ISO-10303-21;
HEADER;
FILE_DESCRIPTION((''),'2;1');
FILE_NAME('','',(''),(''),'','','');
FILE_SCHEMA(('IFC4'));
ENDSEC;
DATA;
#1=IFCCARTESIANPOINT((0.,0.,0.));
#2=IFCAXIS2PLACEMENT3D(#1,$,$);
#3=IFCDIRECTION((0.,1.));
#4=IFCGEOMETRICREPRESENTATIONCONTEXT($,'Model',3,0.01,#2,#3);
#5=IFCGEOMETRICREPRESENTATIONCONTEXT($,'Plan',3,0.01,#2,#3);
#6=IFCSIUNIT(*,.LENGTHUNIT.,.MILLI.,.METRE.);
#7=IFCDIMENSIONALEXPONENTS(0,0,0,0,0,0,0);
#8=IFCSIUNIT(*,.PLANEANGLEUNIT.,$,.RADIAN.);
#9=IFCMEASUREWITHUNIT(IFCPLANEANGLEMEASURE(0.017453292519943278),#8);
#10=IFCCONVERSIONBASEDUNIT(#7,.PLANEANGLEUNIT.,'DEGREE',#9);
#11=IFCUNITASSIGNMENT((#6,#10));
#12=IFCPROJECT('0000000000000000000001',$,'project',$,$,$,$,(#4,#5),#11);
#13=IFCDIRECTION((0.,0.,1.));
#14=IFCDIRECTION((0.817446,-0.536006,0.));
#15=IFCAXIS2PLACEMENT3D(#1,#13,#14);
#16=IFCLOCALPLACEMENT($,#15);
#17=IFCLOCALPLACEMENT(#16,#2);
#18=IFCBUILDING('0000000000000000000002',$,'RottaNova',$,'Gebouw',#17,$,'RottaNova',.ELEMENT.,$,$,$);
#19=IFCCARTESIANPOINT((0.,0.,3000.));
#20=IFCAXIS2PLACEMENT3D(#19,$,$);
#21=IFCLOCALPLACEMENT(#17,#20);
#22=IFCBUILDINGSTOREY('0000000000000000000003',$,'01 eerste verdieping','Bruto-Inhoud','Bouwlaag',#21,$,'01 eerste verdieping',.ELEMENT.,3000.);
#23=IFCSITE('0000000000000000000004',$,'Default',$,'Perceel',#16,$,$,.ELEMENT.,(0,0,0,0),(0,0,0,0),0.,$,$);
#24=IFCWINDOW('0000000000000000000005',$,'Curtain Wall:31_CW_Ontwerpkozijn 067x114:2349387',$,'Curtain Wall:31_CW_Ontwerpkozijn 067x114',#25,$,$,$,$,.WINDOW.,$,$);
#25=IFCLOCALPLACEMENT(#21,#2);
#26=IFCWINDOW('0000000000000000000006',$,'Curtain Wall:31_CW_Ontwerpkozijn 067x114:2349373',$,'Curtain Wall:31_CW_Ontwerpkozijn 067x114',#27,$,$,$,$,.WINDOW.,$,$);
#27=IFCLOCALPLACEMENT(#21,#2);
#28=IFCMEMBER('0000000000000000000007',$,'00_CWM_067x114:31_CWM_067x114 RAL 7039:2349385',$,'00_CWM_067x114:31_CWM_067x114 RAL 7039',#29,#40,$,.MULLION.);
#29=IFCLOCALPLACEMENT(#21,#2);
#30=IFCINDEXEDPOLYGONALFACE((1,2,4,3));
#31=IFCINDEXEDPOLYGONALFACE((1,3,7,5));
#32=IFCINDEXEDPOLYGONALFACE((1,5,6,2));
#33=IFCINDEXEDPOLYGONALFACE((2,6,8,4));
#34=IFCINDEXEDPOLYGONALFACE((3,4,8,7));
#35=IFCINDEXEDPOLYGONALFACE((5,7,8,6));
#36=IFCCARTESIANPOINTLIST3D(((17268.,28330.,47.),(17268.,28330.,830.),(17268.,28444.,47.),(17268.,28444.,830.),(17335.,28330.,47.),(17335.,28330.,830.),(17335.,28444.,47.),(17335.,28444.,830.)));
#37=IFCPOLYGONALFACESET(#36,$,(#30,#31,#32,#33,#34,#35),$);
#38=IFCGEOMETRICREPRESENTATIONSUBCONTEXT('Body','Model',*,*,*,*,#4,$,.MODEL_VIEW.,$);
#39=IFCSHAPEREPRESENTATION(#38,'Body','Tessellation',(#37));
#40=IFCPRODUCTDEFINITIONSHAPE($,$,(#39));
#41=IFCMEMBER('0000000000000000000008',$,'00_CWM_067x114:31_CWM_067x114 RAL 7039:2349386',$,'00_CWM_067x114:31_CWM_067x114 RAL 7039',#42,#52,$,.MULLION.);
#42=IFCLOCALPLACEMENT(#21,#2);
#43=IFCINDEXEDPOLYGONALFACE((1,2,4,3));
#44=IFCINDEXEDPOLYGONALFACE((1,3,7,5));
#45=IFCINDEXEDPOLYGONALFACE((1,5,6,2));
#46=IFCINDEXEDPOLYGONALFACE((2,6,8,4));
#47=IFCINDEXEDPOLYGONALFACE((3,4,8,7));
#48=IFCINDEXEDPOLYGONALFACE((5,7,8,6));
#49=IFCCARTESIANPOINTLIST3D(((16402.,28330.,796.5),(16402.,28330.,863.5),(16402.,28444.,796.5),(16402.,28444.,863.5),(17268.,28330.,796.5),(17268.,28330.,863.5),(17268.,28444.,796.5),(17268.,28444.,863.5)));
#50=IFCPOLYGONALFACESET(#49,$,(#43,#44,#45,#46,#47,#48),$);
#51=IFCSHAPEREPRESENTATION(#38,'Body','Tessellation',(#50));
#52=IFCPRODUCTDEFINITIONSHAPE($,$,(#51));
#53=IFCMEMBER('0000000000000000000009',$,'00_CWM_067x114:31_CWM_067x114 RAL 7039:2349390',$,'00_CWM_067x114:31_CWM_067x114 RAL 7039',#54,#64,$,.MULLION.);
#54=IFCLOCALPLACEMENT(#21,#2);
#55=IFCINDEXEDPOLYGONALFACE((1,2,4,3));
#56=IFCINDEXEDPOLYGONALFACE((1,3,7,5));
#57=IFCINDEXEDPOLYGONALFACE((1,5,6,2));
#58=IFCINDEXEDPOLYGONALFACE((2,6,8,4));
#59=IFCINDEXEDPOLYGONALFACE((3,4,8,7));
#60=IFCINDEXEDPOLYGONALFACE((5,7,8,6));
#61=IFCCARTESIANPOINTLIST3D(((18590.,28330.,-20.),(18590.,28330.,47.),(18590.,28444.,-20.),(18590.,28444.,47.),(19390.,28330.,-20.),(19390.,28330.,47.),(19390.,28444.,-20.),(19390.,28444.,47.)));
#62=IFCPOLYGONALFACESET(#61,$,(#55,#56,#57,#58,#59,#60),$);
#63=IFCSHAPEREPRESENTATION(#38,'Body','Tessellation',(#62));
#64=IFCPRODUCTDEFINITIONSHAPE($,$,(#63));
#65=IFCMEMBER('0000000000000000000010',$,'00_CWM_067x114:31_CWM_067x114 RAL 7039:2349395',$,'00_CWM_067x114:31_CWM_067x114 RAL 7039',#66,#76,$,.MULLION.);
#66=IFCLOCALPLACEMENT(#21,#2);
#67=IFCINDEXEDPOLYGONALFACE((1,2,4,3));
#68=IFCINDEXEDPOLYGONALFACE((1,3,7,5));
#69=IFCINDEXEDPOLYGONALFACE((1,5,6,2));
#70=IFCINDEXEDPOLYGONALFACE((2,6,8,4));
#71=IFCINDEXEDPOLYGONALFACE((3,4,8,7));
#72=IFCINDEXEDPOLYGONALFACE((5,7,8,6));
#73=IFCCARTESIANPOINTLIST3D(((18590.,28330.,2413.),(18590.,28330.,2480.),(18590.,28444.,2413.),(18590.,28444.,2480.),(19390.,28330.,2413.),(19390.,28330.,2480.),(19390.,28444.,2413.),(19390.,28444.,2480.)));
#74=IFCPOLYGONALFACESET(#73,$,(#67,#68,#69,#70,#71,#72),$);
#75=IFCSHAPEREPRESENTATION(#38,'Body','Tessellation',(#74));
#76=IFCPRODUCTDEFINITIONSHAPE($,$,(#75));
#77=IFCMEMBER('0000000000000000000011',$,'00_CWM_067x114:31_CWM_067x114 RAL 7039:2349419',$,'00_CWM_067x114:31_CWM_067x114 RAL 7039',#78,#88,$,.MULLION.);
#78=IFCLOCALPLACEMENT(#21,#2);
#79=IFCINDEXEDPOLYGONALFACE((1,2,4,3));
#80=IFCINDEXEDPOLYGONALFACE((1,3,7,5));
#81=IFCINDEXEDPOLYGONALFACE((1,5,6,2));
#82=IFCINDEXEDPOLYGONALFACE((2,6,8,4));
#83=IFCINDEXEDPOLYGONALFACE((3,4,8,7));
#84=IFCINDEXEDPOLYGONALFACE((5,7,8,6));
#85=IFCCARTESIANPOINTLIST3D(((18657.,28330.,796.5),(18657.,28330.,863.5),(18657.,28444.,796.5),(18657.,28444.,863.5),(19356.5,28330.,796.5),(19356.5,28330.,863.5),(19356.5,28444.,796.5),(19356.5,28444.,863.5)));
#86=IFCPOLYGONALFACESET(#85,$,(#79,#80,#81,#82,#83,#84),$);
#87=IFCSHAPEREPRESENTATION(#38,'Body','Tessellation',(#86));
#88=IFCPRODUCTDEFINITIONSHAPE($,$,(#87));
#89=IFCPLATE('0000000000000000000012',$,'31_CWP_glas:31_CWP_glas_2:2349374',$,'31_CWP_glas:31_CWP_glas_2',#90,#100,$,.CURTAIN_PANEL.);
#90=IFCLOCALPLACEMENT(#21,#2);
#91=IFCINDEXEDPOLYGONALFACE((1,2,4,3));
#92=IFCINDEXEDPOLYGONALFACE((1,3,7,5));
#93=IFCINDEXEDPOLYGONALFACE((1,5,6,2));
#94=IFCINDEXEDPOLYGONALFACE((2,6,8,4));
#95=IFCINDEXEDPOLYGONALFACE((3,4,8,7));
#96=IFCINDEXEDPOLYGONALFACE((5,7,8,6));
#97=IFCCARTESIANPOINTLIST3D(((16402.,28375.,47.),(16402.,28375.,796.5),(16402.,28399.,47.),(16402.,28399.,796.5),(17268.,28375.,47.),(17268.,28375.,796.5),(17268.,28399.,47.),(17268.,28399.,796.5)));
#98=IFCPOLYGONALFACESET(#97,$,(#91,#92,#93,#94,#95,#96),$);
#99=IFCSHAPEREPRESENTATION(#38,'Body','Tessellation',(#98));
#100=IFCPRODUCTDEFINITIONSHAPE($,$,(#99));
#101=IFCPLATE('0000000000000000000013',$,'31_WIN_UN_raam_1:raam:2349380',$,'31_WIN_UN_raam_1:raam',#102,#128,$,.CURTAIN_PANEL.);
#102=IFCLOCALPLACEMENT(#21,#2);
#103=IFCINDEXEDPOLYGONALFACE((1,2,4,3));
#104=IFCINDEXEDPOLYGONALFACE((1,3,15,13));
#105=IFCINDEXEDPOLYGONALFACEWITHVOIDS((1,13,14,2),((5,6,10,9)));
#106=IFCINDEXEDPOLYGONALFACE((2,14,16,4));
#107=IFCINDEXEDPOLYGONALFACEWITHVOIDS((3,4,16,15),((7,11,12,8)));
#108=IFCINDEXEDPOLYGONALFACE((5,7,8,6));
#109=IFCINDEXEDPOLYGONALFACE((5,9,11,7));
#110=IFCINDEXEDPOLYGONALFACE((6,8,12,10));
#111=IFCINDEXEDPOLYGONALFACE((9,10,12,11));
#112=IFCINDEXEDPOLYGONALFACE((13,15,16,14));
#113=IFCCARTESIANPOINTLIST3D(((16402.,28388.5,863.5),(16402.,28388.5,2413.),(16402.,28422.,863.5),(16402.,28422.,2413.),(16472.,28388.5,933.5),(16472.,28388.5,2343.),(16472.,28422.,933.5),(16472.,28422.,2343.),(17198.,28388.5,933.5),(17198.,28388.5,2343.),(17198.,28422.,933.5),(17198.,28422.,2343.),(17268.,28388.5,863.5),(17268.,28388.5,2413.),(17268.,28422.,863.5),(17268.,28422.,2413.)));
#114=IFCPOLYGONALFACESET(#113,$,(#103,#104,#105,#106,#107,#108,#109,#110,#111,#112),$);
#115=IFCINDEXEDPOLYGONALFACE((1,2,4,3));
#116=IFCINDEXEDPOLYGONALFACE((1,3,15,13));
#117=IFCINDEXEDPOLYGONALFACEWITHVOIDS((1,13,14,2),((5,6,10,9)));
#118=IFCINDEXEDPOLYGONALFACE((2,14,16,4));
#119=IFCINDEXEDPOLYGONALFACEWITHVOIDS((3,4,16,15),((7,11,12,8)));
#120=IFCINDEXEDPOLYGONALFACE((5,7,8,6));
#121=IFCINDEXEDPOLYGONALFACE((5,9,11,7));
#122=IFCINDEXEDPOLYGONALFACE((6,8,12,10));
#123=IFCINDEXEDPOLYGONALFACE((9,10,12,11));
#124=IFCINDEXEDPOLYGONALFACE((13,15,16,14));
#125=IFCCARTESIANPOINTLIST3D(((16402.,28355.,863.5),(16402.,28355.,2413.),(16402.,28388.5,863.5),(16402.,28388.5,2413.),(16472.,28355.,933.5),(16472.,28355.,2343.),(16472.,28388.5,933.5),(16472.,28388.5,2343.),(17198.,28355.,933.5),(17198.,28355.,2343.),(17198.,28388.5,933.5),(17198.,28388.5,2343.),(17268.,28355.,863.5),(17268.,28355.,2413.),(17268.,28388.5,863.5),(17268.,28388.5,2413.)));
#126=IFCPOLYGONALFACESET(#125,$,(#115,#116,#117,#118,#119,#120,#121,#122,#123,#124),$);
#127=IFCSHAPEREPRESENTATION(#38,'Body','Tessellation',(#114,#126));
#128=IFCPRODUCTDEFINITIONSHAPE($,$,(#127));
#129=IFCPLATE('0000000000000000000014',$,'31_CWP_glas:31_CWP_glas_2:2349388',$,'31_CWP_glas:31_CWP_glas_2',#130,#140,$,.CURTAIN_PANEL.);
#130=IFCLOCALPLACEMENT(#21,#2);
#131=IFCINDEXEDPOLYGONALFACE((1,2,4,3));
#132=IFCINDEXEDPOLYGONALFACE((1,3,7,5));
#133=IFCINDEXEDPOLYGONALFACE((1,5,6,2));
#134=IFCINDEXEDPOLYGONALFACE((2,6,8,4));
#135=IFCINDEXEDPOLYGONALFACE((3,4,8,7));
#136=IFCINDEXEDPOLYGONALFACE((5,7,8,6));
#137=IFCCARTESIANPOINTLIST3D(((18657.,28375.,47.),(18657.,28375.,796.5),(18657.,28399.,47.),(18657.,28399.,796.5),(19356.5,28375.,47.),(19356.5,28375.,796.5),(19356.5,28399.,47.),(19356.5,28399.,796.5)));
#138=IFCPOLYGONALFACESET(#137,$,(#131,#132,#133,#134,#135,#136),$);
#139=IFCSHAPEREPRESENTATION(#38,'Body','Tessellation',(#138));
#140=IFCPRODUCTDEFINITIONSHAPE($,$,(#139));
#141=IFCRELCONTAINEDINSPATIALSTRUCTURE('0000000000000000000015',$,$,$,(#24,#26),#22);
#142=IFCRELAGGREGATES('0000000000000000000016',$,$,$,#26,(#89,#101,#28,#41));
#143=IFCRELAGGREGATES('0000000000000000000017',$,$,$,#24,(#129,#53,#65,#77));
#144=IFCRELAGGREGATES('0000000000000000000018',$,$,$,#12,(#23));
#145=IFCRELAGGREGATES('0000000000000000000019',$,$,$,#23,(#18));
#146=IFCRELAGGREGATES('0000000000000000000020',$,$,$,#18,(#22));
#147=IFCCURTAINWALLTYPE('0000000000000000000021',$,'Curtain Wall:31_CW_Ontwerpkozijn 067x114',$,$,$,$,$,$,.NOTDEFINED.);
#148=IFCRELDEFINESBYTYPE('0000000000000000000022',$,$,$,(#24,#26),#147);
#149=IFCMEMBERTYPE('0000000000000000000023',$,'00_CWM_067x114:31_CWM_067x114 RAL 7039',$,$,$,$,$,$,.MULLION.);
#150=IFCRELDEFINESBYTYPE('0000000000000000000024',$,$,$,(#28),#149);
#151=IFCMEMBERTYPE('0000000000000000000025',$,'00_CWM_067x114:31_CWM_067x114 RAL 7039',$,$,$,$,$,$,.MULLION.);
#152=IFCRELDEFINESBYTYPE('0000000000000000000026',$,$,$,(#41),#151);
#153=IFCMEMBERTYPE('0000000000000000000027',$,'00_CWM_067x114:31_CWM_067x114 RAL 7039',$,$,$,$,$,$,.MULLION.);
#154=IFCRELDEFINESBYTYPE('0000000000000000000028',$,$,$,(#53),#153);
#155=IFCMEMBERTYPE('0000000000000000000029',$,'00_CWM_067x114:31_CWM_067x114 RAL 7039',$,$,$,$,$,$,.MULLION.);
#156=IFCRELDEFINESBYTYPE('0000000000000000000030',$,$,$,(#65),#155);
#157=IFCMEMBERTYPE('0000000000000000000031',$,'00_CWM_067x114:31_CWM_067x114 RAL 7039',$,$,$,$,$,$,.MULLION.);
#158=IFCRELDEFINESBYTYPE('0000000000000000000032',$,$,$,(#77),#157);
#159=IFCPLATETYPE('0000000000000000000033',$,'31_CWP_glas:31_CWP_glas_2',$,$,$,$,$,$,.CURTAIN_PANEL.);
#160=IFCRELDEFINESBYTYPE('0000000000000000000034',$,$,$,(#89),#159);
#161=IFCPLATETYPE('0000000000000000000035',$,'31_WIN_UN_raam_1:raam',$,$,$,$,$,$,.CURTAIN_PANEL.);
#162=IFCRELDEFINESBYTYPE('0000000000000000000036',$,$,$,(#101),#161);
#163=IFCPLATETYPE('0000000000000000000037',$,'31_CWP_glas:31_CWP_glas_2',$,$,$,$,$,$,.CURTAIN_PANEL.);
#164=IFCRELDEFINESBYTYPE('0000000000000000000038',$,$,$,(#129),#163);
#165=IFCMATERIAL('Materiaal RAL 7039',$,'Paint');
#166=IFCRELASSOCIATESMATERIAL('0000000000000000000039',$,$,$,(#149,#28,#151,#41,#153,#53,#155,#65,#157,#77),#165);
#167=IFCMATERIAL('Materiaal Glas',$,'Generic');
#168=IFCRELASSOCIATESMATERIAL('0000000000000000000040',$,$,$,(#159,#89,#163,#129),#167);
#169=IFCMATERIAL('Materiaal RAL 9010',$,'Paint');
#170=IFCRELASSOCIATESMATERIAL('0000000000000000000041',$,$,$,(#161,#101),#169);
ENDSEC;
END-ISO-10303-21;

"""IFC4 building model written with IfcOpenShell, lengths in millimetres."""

from ifc_helpers import new_model, entity, si_unit, converted_unit, direction, frame, origin, place, context, subcontext, project, spatial, indexed_curve, outline, extrude, source, transform, mapped, material, type_object, type_shapes, element, aggregate, save


model = new_model("IFC4")

# Units and contexts
model_context = context("Model", 3, precision=0.01, world=origin(), true_north=direction((0.0, 1.0)))
plan_context = context("Plan", 3, precision=0.01, world=origin(), true_north=direction((0.0, 1.0)))
body_context = subcontext(model_context, "Body", "Model", "MODEL_VIEW")
ifc_project = project(units=[si_unit("LENGTHUNIT", "METRE", prefix="MILLI"), converted_unit("PLANEANGLEUNIT", "DEGREE", entity("IfcPlaneAngleMeasure", 0.017453292519943278), si_unit("PLANEANGLEUNIT", "RADIAN"), dimensions=[0, 0, 0, 0, 0, 0, 0])], contexts=[model_context, plan_context])

# Site, building, storey
site_placement = place(None, frame((0.0, 0.0, 0.0), z_axis=(0.0, 0.0, 1.0), x_axis=(0.817446, -0.536006, 0.0)))
site = spatial("IfcSite", under=ifc_project, at=site_placement, Name="Default", ObjectType="Perceel", CompositionType="ELEMENT", RefLatitude=(0, 0, 0, 0), RefLongitude=(0, 0, 0, 0), RefElevation=0.0)
building_placement = place(site_placement, origin())
building = spatial("IfcBuilding", under=site, at=building_placement, Name="RottaNova", ObjectType="Gebouw", LongName="RottaNova", CompositionType="ELEMENT")
storey_placement = place(building_placement, frame((0.0, 0.0, 3000.0)))
storey = spatial("IfcBuildingStorey", under=building, at=storey_placement, Name="01 eerste verdieping", Description="Bruto-Inhoud", ObjectType="Bouwlaag", LongName="01 eerste verdieping", CompositionType="ELEMENT", Elevation=3000.0)

# Windows, members
curtain_wall_type = type_object("IfcCurtainWallType", Name="Curtain Wall:31_CW_Ontwerpkozijn 067x114", PredefinedType="NOTDEFINED")
window_1_placement = place(storey_placement, frame((0.0, 0.0, -3000.0)))
window_1 = element("IfcWindow", 1, at=window_1_placement, inside=storey, type_object=curtain_wall_type, Name="Curtain Wall:31_CW_Ontwerpkozijn 067x114:2349387", ObjectType="Curtain Wall:31_CW_Ontwerpkozijn 067x114", PredefinedType="WINDOW")
ifc_material_1 = material(Name="Materiaal RAL 7039", Category="Paint")
window_2_placement = place(storey_placement, frame((0.0, 0.0, -3000.0)))
window_2 = element("IfcWindow", 2, at=window_2_placement, inside=storey, type_object=curtain_wall_type, Name="Curtain Wall:31_CW_Ontwerpkozijn 067x114:2349373", ObjectType="Curtain Wall:31_CW_Ontwerpkozijn 067x114", PredefinedType="WINDOW")
member_type_1 = type_object("IfcMemberType", Name="00_CWM_067x114:31_CWM_067x114 RAL 7039", PredefinedType="MULLION", material=ifc_material_1)
shared_shape_1 = source(origin(), body_context, "Body", "SweptSolid", [
    extrude(outline(indexed_curve([(-33.5, -57.0), (33.5, -57.0), (33.5, 57.0), (-33.5, 57.0), (-33.5, -57.0)], self_intersect=False)), frame((-33.5, 57.0, -783.0), z_axis=(0.0, 0.0, 1.0), x_axis=(-1.0, 0.0, 0.0)), (0.0, 0.0, 1.0), 783.0),
])
type_shapes(member_type_1, [shared_shape_1])
member_1_placement = place(window_2_placement, frame((17335.0, 28330.0, 3830.0)))
member_1 = element("IfcMember", 3, at=member_1_placement, type_object=member_type_1, material=ifc_material_1, Name="00_CWM_067x114:31_CWM_067x114 RAL 7039:2349385", ObjectType="00_CWM_067x114:31_CWM_067x114 RAL 7039", PredefinedType="MULLION", context=body_context, shape_type="MappedRepresentation", body=[
    mapped(shared_shape_1, transform((0.0, 0.0, 0.0), scale=1.0)),
])
member_type_2 = type_object("IfcMemberType", Name="00_CWM_067x114:31_CWM_067x114 RAL 7039", PredefinedType="MULLION", material=ifc_material_1)
shared_shape_2 = source(origin(), body_context, "Body", "SweptSolid", [
    extrude(outline(indexed_curve([(-33.5, -57.0), (33.5, -57.0), (33.5, 57.0), (-33.5, 57.0), (-33.5, -57.0)], self_intersect=False)), frame((0.0, 57.0, -866.0), z_axis=(0.0, 0.0, 1.0), x_axis=(-1.0, 0.0, 0.0)), (0.0, 0.0, 1.0), 866.0),
])
type_shapes(member_type_2, [shared_shape_2])
member_2_placement = place(window_2_placement, frame((16402.0, 28330.0, 3830.0), z_axis=(-1.0, 0.0, 0.0), x_axis=(0.0, 0.0, 1.0)))
member_2 = element("IfcMember", 4, at=member_2_placement, type_object=member_type_2, material=ifc_material_1, Name="00_CWM_067x114:31_CWM_067x114 RAL 7039:2349386", ObjectType="00_CWM_067x114:31_CWM_067x114 RAL 7039", PredefinedType="MULLION", context=body_context, shape_type="MappedRepresentation", body=[
    mapped(shared_shape_2, transform((0.0, 0.0, 0.0), scale=1.0)),
])

# Members
member_type_3 = type_object("IfcMemberType", Name="00_CWM_067x114:31_CWM_067x114 RAL 7039", PredefinedType="MULLION", material=ifc_material_1)
shared_shape_3 = source(origin(), body_context, "Body", "SweptSolid", [
    extrude(outline(indexed_curve([(-33.5, -57.0), (33.5, -57.0), (33.5, 57.0), (-33.5, 57.0), (-33.5, -57.0)], self_intersect=False)), frame((-33.5, -57.0, -800.0), z_axis=(0.0, 0.0, 1.0), x_axis=(-1.0, 0.0, 0.0)), (0.0, 0.0, 1.0), 800.0),
])
type_shapes(member_type_3, [shared_shape_3])
member_3_placement = place(window_1_placement, frame((18590.0, 28330.0, 2980.0), z_axis=(-1.0, 0.0, 0.0), x_axis=(0.0, 0.0, -1.0)))
member_3 = element("IfcMember", 5, at=member_3_placement, type_object=member_type_3, material=ifc_material_1, Name="00_CWM_067x114:31_CWM_067x114 RAL 7039:2349390", ObjectType="00_CWM_067x114:31_CWM_067x114 RAL 7039", PredefinedType="MULLION", context=body_context, shape_type="MappedRepresentation", body=[
    mapped(shared_shape_3, transform((0.0, 0.0, 0.0), scale=1.0)),
])
member_type_4 = type_object("IfcMemberType", Name="00_CWM_067x114:31_CWM_067x114 RAL 7039", PredefinedType="MULLION", material=ifc_material_1)
shared_shape_4 = source(origin(), body_context, "Body", "SweptSolid", [
    extrude(outline(indexed_curve([(-33.5, -57.0), (33.5, -57.0), (33.5, 57.0), (-33.5, 57.0), (-33.5, -57.0)], self_intersect=False)), frame((-33.5, -57.0, -800.0), z_axis=(0.0, 0.0, 1.0), x_axis=(-1.0, 0.0, 0.0)), (0.0, 0.0, 1.0), 800.0),
])
type_shapes(member_type_4, [shared_shape_4])
member_4_placement = place(window_1_placement, frame((19390.0, 28330.0, 5480.0), z_axis=(1.0, 0.0, 0.0), x_axis=(0.0, 0.0, 1.0)))
member_4 = element("IfcMember", 6, at=member_4_placement, type_object=member_type_4, material=ifc_material_1, Name="00_CWM_067x114:31_CWM_067x114 RAL 7039:2349395", ObjectType="00_CWM_067x114:31_CWM_067x114 RAL 7039", PredefinedType="MULLION", context=body_context, shape_type="MappedRepresentation", body=[
    mapped(shared_shape_4, transform((0.0, 0.0, 0.0), scale=1.0)),
])
member_type_5 = type_object("IfcMemberType", Name="00_CWM_067x114:31_CWM_067x114 RAL 7039", PredefinedType="MULLION", material=ifc_material_1)
shared_shape_5 = source(origin(), body_context, "Body", "SweptSolid", [
    extrude(outline(indexed_curve([(-33.5, -57.0), (33.5, -57.0), (33.5, 57.0), (-33.5, 57.0), (-33.5, -57.0)], self_intersect=False)), frame((0.0, -57.0, -699.5), z_axis=(0.0, 0.0, 1.0), x_axis=(-1.0, 0.0, 0.0)), (0.0, 0.0, 1.0), 699.5),
])
type_shapes(member_type_5, [shared_shape_5])
member_5_placement = place(window_1_placement, frame((19356.5, 28330.0, 3830.0), z_axis=(1.0, 0.0, 0.0), x_axis=(0.0, 0.0, 1.0)))
member_5 = element("IfcMember", 7, at=member_5_placement, type_object=member_type_5, material=ifc_material_1, Name="00_CWM_067x114:31_CWM_067x114 RAL 7039:2349419", ObjectType="00_CWM_067x114:31_CWM_067x114 RAL 7039", PredefinedType="MULLION", context=body_context, shape_type="MappedRepresentation", body=[
    mapped(shared_shape_5, transform((0.0, 0.0, 0.0), scale=1.0)),
])

# Plates
ifc_material_2 = material(Name="Materiaal Glas", Category="Generic")
plate_type_1 = type_object("IfcPlateType", Name="31_CWP_glas:31_CWP_glas_2", PredefinedType="CURTAIN_PANEL", material=ifc_material_2)
shared_shape_6 = source(origin(), body_context, "Body", "SweptSolid", [
    extrude(outline(indexed_curve([(-12.0, -433.0), (12.0, -433.0), (12.0, 433.0), (-12.0, 433.0), (-12.0, -433.0)], self_intersect=False)), frame((0.0, -57.0, 0.0), z_axis=(0.0, 0.0, 1.0), x_axis=(0.0, 1.0, 0.0)), (0.0, 0.0, 1.0), 749.5),
])
type_shapes(plate_type_1, [shared_shape_6])
plate_1_placement = place(window_2_placement, frame((16835.0, 28330.0, 3047.0), z_axis=(0.0, 0.0, 1.0), x_axis=(-1.0, 0.0, 0.0)))
plate_1 = element("IfcPlate", 8, at=plate_1_placement, type_object=plate_type_1, material=ifc_material_2, Name="31_CWP_glas:31_CWP_glas_2:2349374", ObjectType="31_CWP_glas:31_CWP_glas_2", PredefinedType="CURTAIN_PANEL", context=body_context, shape_type="MappedRepresentation", body=[
    mapped(shared_shape_6, transform((0.0, 0.0, 0.0), scale=1.0)),
])
ifc_material_3 = material(Name="Materiaal RAL 9010", Category="Paint")
plate_type_2 = type_object("IfcPlateType", Name="31_WIN_UN_raam_1:raam", PredefinedType="CURTAIN_PANEL", material=ifc_material_3)
shared_shape_7 = source(origin(), body_context, "Body", "SweptSolid", [
    extrude(outline(indexed_curve([(-433.0, -774.7), (433.0, -774.7), (433.0, 774.7), (-433.0, 774.7), (-433.0, -774.7)], self_intersect=False), holes=[indexed_curve([(-363.0, 704.7), (363.0, 704.7), (363.0, -704.8), (-363.0, -704.8), (-363.0, 704.7)], self_intersect=False)]), frame((0.0, -92.0, 774.8), z_axis=(0.0, 1.0, 0.0), x_axis=(1.0, 0.0, 0.0)), (0.0, 0.0, 1.0), 33.5),
    extrude(outline(indexed_curve([(-433.0, -774.7), (433.0, -774.7), (433.0, 774.7), (-433.0, 774.7), (-433.0, -774.7)], self_intersect=False), holes=[indexed_curve([(-363.0, 704.7), (363.0, 704.7), (363.0, -704.8), (-363.0, -704.8), (-363.0, 704.7)], self_intersect=False)]), frame((0.0, -58.5, 774.8), z_axis=(0.0, 1.0, 0.0), x_axis=(1.0, 0.0, 0.0)), (0.0, 0.0, 1.0), 33.5),
])
type_shapes(plate_type_2, [shared_shape_7])
plate_2_placement = place(window_2_placement, frame((16835.0, 28330.0, 3863.5), z_axis=(0.0, 0.0, 1.0), x_axis=(-1.0, 0.0, 0.0)))
plate_2 = element("IfcPlate", 9, at=plate_2_placement, type_object=plate_type_2, material=ifc_material_3, Name="31_WIN_UN_raam_1:raam:2349380", ObjectType="31_WIN_UN_raam_1:raam", PredefinedType="CURTAIN_PANEL", context=body_context, shape_type="MappedRepresentation", body=[
    mapped(shared_shape_7, transform((0.0, 0.0, 0.0), scale=1.0)),
])
aggregate(window_2, [plate_1, plate_2, member_1, member_2])
plate_type_3 = type_object("IfcPlateType", Name="31_CWP_glas:31_CWP_glas_2", PredefinedType="CURTAIN_PANEL", material=ifc_material_2)
shared_shape_8 = source(origin(), body_context, "Body", "SweptSolid", [
    extrude(outline(indexed_curve([(-12.0, -349.8), (12.0, -349.8), (12.0, 349.8), (-12.0, 349.8), (-12.0, -349.8)], self_intersect=False)), frame((0.0, 57.0, 0.0), z_axis=(0.0, 0.0, 1.0), x_axis=(0.0, 1.0, 0.0)), (0.0, 0.0, 1.0), 749.5),
])
type_shapes(plate_type_3, [shared_shape_8])
plate_3_placement = place(window_1_placement, frame((19006.8, 28330.0, 3047.0)))
plate_3 = element("IfcPlate", 10, at=plate_3_placement, type_object=plate_type_3, material=ifc_material_2, Name="31_CWP_glas:31_CWP_glas_2:2349388", ObjectType="31_CWP_glas:31_CWP_glas_2", PredefinedType="CURTAIN_PANEL", context=body_context, shape_type="MappedRepresentation", body=[
    mapped(shared_shape_8, transform((0.0, 0.0, 0.0), scale=1.0)),
])
aggregate(window_1, [plate_3, member_3, member_4, member_5])

save(model, "model.ifc")
